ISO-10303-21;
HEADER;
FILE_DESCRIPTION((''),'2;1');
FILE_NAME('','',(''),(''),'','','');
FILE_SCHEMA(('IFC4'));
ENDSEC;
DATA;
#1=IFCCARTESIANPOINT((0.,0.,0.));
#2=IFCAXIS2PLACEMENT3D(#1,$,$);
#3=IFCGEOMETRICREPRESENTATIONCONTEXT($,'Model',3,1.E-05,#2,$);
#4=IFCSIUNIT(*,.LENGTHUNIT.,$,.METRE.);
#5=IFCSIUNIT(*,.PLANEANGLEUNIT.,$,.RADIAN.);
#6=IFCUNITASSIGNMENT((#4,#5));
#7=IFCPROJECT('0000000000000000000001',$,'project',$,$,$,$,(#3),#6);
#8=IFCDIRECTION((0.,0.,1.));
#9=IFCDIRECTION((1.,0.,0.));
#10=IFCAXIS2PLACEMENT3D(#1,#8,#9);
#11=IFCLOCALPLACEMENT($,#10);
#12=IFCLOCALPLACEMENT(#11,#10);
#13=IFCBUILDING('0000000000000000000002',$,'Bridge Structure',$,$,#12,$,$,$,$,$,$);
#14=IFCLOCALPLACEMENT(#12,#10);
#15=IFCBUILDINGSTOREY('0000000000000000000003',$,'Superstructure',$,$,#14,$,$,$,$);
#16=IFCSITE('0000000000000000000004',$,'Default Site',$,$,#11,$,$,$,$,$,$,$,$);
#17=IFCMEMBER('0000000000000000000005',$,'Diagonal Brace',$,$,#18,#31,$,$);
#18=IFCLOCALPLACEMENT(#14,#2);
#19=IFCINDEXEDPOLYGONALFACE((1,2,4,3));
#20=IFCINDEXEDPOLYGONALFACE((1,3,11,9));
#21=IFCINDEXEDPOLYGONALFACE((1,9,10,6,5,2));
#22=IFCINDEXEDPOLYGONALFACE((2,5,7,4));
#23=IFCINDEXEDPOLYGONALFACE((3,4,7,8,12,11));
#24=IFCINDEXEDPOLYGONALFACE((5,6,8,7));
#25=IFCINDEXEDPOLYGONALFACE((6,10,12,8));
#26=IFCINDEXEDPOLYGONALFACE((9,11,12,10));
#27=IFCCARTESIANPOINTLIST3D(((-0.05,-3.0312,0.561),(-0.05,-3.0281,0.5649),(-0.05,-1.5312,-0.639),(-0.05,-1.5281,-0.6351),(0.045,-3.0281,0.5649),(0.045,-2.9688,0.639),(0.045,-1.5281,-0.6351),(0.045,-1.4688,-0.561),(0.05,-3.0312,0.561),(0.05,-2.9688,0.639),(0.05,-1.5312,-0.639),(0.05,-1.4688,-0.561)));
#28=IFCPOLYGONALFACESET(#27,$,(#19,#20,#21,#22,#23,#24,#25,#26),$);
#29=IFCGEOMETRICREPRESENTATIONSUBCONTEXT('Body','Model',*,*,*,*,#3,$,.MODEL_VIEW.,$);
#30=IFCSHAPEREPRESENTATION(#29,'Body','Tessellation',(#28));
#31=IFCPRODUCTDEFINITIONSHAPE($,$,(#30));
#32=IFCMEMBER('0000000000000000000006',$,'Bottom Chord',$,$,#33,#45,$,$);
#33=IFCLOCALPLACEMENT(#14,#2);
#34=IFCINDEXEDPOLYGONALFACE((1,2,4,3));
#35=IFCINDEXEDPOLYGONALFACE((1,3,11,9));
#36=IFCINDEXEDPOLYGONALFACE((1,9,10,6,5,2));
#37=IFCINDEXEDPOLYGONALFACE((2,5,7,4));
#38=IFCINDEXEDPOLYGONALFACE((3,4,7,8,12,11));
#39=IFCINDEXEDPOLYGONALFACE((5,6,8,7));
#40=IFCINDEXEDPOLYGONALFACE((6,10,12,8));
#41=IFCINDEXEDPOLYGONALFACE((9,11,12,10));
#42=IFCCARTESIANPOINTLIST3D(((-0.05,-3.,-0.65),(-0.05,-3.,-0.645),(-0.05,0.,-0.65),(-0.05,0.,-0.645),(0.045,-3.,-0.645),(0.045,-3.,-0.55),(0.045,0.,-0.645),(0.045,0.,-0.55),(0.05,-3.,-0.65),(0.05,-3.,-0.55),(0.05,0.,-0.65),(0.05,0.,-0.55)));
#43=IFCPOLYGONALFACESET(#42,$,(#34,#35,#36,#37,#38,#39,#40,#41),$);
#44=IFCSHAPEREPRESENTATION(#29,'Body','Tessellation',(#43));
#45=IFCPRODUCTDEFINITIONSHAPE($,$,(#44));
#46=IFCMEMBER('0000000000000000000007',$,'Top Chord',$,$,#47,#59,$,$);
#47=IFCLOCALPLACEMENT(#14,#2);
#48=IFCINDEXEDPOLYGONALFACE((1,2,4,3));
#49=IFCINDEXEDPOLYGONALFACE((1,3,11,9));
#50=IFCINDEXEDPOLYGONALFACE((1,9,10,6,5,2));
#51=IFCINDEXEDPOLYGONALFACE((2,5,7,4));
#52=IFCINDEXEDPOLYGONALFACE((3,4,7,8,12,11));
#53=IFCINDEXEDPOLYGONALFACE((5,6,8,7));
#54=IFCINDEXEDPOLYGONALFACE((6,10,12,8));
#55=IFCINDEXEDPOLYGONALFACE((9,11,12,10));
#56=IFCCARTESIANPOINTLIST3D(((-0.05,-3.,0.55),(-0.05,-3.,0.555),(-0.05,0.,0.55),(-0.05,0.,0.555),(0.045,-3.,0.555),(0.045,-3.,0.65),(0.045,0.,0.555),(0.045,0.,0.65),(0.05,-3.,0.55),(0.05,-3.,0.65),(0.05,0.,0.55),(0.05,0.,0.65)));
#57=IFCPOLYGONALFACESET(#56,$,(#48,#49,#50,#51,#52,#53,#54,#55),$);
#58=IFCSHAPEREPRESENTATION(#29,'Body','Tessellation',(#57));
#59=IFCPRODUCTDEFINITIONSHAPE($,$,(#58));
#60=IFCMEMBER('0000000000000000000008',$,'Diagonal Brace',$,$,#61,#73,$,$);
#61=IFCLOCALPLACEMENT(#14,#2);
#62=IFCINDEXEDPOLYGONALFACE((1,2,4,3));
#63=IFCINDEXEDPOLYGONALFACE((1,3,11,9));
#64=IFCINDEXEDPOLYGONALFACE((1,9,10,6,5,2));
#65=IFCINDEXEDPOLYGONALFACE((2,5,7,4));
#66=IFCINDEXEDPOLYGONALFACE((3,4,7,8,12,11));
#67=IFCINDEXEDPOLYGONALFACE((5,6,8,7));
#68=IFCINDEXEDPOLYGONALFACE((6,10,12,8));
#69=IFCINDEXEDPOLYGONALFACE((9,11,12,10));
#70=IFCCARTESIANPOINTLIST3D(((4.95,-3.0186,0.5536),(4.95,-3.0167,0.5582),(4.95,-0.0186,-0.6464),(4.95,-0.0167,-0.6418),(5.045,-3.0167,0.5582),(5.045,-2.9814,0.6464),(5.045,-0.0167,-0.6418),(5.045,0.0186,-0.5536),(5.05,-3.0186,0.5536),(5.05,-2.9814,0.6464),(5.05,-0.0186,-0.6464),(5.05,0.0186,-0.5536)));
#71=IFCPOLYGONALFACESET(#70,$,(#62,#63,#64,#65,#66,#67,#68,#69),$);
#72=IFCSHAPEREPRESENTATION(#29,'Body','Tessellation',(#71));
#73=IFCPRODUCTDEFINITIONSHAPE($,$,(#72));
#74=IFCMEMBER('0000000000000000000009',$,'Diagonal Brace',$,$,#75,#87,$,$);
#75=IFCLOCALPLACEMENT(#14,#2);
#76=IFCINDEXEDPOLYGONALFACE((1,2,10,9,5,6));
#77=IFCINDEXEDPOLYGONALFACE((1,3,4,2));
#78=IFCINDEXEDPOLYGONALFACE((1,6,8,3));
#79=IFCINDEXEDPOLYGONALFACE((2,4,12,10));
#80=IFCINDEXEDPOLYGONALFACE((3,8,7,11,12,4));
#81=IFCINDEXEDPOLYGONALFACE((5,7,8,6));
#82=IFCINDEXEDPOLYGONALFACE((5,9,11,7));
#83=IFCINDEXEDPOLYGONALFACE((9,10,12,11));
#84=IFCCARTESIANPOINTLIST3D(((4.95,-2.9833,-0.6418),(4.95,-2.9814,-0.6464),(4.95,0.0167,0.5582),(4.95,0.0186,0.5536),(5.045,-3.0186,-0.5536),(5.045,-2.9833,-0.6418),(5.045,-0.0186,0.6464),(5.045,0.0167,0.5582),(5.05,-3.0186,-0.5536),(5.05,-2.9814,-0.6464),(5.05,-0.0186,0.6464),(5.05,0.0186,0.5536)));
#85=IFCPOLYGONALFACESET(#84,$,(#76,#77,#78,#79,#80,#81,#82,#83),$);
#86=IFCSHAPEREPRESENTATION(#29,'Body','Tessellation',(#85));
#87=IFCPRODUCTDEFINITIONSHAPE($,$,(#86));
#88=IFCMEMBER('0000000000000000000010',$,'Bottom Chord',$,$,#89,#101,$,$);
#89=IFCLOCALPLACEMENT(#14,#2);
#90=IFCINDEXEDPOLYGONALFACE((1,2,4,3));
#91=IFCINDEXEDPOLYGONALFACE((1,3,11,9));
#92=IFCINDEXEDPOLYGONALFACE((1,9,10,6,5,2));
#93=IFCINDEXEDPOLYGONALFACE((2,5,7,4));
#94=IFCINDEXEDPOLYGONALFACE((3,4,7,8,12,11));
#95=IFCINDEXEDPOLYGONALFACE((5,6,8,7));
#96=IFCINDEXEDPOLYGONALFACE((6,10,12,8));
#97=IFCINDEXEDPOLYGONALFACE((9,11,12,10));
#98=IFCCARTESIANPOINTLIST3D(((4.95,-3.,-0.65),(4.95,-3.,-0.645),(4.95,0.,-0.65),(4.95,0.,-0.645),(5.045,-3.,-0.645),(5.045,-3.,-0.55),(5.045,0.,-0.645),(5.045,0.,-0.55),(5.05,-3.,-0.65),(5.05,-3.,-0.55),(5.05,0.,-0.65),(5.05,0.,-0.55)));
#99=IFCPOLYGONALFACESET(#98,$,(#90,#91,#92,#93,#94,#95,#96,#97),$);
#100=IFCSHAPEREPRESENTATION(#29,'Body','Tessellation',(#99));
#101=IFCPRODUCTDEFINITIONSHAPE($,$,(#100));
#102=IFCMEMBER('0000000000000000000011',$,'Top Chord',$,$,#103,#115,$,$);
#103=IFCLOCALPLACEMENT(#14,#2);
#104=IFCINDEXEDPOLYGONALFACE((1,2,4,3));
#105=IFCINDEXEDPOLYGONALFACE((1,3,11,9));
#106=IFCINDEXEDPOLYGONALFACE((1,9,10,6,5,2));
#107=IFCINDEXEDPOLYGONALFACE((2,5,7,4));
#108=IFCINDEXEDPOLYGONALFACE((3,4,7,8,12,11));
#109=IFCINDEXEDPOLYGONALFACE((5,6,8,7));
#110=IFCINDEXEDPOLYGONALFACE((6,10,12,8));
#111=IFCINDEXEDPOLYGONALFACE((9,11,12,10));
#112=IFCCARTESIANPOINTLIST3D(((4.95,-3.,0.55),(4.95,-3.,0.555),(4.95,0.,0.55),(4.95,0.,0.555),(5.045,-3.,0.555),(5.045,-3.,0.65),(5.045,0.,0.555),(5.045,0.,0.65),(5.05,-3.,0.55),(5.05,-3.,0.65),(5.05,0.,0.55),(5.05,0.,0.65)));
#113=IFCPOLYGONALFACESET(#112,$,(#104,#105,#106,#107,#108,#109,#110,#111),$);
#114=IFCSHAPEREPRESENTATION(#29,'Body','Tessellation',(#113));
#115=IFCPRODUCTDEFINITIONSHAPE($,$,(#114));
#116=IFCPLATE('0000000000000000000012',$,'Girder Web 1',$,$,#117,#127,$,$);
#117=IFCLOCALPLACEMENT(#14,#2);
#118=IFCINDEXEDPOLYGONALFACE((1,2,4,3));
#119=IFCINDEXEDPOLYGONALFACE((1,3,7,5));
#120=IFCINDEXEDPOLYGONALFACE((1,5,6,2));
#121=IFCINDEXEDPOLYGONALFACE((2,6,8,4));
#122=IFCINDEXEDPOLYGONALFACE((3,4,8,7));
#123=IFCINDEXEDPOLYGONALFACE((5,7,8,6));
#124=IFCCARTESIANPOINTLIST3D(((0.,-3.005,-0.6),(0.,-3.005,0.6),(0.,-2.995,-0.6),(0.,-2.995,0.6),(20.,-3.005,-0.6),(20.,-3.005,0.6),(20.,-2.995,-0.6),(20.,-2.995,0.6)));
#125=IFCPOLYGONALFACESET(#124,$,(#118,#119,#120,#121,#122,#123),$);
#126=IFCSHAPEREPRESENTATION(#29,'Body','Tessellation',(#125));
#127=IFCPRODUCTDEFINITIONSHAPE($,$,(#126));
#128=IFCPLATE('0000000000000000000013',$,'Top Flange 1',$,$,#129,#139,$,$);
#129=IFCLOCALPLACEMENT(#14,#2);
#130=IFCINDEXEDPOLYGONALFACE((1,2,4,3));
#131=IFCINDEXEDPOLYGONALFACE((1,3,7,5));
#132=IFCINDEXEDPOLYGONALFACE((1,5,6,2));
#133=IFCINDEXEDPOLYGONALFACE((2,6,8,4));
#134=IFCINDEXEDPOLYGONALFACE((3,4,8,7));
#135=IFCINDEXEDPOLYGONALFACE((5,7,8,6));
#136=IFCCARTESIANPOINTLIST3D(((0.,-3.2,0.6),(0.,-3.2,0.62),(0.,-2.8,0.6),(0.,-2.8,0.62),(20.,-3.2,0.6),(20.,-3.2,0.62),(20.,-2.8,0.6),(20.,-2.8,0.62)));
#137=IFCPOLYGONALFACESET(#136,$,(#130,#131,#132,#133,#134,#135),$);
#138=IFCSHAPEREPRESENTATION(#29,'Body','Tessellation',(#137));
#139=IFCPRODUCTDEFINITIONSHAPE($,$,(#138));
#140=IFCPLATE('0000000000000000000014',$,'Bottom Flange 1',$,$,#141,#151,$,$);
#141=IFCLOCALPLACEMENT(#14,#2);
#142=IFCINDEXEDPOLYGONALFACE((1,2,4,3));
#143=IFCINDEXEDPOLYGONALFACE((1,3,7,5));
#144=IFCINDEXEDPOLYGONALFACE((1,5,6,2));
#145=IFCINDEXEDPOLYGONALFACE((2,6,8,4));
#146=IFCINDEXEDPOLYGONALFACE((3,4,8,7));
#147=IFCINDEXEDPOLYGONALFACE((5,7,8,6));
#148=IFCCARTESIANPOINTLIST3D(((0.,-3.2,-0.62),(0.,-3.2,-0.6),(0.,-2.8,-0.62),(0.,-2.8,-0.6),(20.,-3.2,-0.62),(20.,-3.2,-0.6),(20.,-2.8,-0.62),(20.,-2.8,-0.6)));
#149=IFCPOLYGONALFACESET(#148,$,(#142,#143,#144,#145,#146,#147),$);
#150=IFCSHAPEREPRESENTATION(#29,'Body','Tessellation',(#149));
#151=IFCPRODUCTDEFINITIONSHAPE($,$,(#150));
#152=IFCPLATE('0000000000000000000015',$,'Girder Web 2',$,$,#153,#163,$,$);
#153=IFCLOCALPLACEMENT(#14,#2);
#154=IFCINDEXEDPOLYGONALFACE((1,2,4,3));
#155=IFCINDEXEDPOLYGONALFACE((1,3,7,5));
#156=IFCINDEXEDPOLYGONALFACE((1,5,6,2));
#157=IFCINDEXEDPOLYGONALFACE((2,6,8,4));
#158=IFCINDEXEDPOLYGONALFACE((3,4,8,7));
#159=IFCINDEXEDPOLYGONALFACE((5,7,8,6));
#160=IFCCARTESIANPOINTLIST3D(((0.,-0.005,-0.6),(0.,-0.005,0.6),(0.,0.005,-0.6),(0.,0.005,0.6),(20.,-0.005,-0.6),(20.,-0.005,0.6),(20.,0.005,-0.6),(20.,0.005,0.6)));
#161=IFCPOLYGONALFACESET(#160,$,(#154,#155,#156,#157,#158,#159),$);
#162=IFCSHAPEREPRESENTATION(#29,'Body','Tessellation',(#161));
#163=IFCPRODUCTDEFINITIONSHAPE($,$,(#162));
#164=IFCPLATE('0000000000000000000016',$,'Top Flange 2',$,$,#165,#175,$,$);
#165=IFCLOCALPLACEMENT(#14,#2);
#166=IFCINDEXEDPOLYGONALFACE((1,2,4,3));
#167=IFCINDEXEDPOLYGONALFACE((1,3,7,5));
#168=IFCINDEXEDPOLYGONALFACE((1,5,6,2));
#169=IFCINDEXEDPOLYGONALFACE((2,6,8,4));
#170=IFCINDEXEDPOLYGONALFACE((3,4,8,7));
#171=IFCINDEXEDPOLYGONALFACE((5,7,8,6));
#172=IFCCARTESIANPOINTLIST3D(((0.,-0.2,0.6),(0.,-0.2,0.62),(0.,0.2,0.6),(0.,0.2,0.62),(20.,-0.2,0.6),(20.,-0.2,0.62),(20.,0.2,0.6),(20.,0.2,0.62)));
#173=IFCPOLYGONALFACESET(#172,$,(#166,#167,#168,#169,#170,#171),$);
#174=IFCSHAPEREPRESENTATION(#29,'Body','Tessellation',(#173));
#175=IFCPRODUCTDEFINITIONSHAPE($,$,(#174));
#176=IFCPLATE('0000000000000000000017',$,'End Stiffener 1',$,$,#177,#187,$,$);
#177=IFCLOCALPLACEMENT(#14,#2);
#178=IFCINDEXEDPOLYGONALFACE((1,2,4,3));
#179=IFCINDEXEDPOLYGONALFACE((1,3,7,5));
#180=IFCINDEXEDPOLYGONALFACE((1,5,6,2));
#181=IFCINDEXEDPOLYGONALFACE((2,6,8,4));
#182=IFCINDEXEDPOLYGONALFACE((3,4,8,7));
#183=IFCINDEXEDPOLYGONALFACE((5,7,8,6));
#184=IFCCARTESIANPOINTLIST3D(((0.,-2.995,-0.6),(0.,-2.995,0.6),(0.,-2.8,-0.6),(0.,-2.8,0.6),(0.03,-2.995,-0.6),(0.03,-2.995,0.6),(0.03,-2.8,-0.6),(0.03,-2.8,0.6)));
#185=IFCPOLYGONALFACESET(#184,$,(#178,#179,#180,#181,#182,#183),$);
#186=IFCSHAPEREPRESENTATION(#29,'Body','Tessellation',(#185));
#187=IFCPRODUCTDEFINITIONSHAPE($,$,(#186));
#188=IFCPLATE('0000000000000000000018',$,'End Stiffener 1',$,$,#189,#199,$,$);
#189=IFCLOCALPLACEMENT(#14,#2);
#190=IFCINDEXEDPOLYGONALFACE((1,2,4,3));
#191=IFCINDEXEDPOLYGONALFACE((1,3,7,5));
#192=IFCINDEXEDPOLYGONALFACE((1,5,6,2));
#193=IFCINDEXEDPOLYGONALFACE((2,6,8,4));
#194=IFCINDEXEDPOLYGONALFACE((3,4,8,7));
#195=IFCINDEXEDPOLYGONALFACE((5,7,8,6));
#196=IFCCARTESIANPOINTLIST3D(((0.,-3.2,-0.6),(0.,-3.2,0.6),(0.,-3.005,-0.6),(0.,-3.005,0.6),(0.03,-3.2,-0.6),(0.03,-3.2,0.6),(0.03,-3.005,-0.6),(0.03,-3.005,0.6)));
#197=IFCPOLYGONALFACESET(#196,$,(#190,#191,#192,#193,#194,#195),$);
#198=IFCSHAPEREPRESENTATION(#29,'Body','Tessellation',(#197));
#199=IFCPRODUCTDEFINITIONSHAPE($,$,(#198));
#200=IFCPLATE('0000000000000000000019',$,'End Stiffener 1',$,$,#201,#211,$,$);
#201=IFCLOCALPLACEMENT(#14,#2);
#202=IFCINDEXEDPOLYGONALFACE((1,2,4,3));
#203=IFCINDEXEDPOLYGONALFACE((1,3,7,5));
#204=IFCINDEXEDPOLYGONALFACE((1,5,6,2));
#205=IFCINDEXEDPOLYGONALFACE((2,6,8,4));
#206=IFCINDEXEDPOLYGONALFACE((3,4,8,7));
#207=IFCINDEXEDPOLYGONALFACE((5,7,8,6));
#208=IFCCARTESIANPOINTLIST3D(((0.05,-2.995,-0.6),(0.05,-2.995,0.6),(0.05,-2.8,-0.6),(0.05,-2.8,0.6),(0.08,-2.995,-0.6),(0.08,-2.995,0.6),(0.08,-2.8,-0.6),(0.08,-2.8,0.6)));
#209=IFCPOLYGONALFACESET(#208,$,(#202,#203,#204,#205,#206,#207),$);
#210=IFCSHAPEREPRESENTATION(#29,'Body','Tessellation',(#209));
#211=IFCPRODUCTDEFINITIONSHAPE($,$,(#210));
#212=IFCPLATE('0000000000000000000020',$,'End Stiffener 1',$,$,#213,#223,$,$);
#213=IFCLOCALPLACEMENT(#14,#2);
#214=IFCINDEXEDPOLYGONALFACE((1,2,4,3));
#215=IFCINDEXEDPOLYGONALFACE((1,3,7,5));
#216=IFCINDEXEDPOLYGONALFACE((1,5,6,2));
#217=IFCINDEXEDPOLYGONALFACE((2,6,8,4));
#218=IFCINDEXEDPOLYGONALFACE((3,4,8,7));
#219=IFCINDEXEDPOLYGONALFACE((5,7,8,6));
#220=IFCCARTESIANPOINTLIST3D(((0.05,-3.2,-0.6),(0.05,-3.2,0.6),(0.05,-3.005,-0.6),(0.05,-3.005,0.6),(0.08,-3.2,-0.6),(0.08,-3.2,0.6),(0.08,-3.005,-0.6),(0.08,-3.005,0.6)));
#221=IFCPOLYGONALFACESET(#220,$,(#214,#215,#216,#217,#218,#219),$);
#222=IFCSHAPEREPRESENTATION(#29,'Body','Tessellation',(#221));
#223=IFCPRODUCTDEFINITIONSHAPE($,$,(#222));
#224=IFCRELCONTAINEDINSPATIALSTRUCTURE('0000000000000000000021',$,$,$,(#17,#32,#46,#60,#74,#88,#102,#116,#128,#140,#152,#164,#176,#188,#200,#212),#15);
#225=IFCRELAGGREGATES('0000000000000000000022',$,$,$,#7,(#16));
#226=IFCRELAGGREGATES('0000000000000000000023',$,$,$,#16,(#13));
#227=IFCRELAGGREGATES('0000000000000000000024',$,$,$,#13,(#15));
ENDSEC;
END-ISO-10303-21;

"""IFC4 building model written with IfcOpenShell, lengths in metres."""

from ifc_helpers import new_model, si_unit, frame, origin, origin_with_axes, origin_2d_with_axis, place, context, subcontext, project, spatial, rectangle, l_section, extrude, element, save


model = new_model("IFC4")

# Units and contexts
model_context = context("Model", 3, precision=1e-05, world=origin())
body_context = subcontext(model_context, "Body", "Model", "MODEL_VIEW")
ifc_project = project(units=[si_unit("LENGTHUNIT", "METRE"), si_unit("PLANEANGLEUNIT", "RADIAN")], contexts=[model_context])

# Site, building, storey
site_placement = place(None, origin_with_axes())
site = spatial("IfcSite", under=ifc_project, at=site_placement, Name="Default Site")
building_placement = place(site_placement, origin_with_axes())
building = spatial("IfcBuilding", under=site, at=building_placement, Name="Bridge Structure")
storey_placement = place(building_placement, origin_with_axes())
storey = spatial("IfcBuildingStorey", under=building, at=storey_placement, Name="Superstructure")

# Members
member_placement = place(storey_placement, frame((0.0, -3.0, 0.6), z_axis=(0.0, 0.780869, -0.624695), x_axis=(-1.0, 0.0, 0.0)))
element("IfcMember", 1, at=member_placement, inside=storey, Name="Diagonal Brace", context=body_context, shape_type="SweptSolid", body=[
    extrude(l_section(Depth=0.1, Width=0.1, Thickness=0.005, at=origin_2d_with_axis()), origin_with_axes(), (0.0, 0.0, 1.0), 1.9209),
])
for number, where, z_axis, x_axis, name in (
    (2, (0.0, -3.0, -0.6), (0.0, 1.0, 0.0), (-1.0, 0.0, 0.0), "Bottom Chord"),
    (3, (0.0, -3.0, 0.6), (0.0, 1.0, 0.0), (-1.0, 0.0, 0.0), "Top Chord"),
):
    element("IfcMember", number, at=place(storey_placement, frame(where, z_axis=z_axis, x_axis=x_axis)), inside=storey, Name=name, context=body_context, shape_type="SweptSolid", body=[
        extrude(l_section(Depth=0.1, Width=0.1, Thickness=0.005, at=origin_2d_with_axis()), origin_with_axes(), (0.0, 0.0, 1.0), 3.0),
    ])
for number, where, z_axis, x_axis, name in (
    (4, (5.0, -3.0, 0.6), (0.0, 0.928477, -0.371391), (-1.0, 0.0, 0.0), "Diagonal Brace"),
    (5, (5.0, -3.0, -0.6), (0.0, 0.928477, 0.371391), (-1.0, 0.0, 0.0), "Diagonal Brace"),
):
    element("IfcMember", number, at=place(storey_placement, frame(where, z_axis=z_axis, x_axis=x_axis)), inside=storey, Name=name, context=body_context, shape_type="SweptSolid", body=[
        extrude(l_section(Depth=0.1, Width=0.1, Thickness=0.005, at=origin_2d_with_axis()), origin_with_axes(), (0.0, 0.0, 1.0), 3.2311),
    ])
for number, where, z_axis, x_axis, name in (
    (6, (5.0, -3.0, -0.6), (0.0, 1.0, 0.0), (-1.0, 0.0, 0.0), "Bottom Chord"),
    (7, (5.0, -3.0, 0.6), (0.0, 1.0, 0.0), (-1.0, 0.0, 0.0), "Top Chord"),
):
    element("IfcMember", number, at=place(storey_placement, frame(where, z_axis=z_axis, x_axis=x_axis)), inside=storey, Name=name, context=body_context, shape_type="SweptSolid", body=[
        extrude(l_section(Depth=0.1, Width=0.1, Thickness=0.005, at=origin_2d_with_axis()), origin_with_axes(), (0.0, 0.0, 1.0), 3.0),
    ])

# Plates
plate_1_placement = place(storey_placement, frame((0.0, -3.0, 0.0), z_axis=(1.0, 0.0, 0.0), x_axis=(0.0, 1.0, 0.0)))
element("IfcPlate", 8, at=plate_1_placement, inside=storey, Name="Girder Web 1", context=body_context, shape_type="SweptSolid", body=[
    extrude(rectangle(XDim=0.01, YDim=1.2, at=origin_2d_with_axis()), origin_with_axes(), (0.0, 0.0, 1.0), 20.0),
])
for number, where, z_axis, x_axis, name in (
    (9, (0.0, -3.0, 0.61), (1.0, 0.0, 0.0), (0.0, 1.0, 0.0), "Top Flange 1"),
    (10, (0.0, -3.0, -0.61), (1.0, 0.0, 0.0), (0.0, 1.0, 0.0), "Bottom Flange 1"),
):
    element("IfcPlate", number, at=place(storey_placement, frame(where, z_axis=z_axis, x_axis=x_axis)), inside=storey, Name=name, context=body_context, shape_type="SweptSolid", body=[
        extrude(rectangle(XDim=0.4, YDim=0.02, at=origin_2d_with_axis()), origin_with_axes(), (0.0, 0.0, 1.0), 20.0),
    ])
plate_2_placement = place(storey_placement, frame((0.0, 0.0, 0.0), z_axis=(1.0, 0.0, 0.0), x_axis=(0.0, 1.0, 0.0)))
element("IfcPlate", 11, at=plate_2_placement, inside=storey, Name="Girder Web 2", context=body_context, shape_type="SweptSolid", body=[
    extrude(rectangle(XDim=0.01, YDim=1.2, at=origin_2d_with_axis()), origin_with_axes(), (0.0, 0.0, 1.0), 20.0),
])
plate_3_placement = place(storey_placement, frame((0.0, 0.0, 0.61), z_axis=(1.0, 0.0, 0.0), x_axis=(0.0, 1.0, 0.0)))
element("IfcPlate", 12, at=plate_3_placement, inside=storey, Name="Top Flange 2", context=body_context, shape_type="SweptSolid", body=[
    extrude(rectangle(XDim=0.4, YDim=0.02, at=origin_2d_with_axis()), origin_with_axes(), (0.0, 0.0, 1.0), 20.0),
])
for number, where, z_axis, x_axis, name in (
    (13, (0.015, -2.8975, -0.6), (0.0, 0.0, 1.0), (1.0, 0.0, 0.0), "End Stiffener 1"),
    (14, (0.015, -3.1025, -0.6), (0.0, 0.0, 1.0), (1.0, 0.0, 0.0), "End Stiffener 1"),
    (15, (0.065, -2.8975, -0.6), (0.0, 0.0, 1.0), (1.0, 0.0, 0.0), "End Stiffener 1"),
    (16, (0.065, -3.1025, -0.6), (0.0, 0.0, 1.0), (1.0, 0.0, 0.0), "End Stiffener 1"),
):
    element("IfcPlate", number, at=place(storey_placement, frame(where, z_axis=z_axis, x_axis=x_axis)), inside=storey, Name=name, context=body_context, shape_type="SweptSolid", body=[
        extrude(rectangle(XDim=0.03, YDim=0.195, at=origin_2d_with_axis()), origin_with_axes(), (0.0, 0.0, 1.0), 1.2),
    ])

save(model, "model.ifc")
